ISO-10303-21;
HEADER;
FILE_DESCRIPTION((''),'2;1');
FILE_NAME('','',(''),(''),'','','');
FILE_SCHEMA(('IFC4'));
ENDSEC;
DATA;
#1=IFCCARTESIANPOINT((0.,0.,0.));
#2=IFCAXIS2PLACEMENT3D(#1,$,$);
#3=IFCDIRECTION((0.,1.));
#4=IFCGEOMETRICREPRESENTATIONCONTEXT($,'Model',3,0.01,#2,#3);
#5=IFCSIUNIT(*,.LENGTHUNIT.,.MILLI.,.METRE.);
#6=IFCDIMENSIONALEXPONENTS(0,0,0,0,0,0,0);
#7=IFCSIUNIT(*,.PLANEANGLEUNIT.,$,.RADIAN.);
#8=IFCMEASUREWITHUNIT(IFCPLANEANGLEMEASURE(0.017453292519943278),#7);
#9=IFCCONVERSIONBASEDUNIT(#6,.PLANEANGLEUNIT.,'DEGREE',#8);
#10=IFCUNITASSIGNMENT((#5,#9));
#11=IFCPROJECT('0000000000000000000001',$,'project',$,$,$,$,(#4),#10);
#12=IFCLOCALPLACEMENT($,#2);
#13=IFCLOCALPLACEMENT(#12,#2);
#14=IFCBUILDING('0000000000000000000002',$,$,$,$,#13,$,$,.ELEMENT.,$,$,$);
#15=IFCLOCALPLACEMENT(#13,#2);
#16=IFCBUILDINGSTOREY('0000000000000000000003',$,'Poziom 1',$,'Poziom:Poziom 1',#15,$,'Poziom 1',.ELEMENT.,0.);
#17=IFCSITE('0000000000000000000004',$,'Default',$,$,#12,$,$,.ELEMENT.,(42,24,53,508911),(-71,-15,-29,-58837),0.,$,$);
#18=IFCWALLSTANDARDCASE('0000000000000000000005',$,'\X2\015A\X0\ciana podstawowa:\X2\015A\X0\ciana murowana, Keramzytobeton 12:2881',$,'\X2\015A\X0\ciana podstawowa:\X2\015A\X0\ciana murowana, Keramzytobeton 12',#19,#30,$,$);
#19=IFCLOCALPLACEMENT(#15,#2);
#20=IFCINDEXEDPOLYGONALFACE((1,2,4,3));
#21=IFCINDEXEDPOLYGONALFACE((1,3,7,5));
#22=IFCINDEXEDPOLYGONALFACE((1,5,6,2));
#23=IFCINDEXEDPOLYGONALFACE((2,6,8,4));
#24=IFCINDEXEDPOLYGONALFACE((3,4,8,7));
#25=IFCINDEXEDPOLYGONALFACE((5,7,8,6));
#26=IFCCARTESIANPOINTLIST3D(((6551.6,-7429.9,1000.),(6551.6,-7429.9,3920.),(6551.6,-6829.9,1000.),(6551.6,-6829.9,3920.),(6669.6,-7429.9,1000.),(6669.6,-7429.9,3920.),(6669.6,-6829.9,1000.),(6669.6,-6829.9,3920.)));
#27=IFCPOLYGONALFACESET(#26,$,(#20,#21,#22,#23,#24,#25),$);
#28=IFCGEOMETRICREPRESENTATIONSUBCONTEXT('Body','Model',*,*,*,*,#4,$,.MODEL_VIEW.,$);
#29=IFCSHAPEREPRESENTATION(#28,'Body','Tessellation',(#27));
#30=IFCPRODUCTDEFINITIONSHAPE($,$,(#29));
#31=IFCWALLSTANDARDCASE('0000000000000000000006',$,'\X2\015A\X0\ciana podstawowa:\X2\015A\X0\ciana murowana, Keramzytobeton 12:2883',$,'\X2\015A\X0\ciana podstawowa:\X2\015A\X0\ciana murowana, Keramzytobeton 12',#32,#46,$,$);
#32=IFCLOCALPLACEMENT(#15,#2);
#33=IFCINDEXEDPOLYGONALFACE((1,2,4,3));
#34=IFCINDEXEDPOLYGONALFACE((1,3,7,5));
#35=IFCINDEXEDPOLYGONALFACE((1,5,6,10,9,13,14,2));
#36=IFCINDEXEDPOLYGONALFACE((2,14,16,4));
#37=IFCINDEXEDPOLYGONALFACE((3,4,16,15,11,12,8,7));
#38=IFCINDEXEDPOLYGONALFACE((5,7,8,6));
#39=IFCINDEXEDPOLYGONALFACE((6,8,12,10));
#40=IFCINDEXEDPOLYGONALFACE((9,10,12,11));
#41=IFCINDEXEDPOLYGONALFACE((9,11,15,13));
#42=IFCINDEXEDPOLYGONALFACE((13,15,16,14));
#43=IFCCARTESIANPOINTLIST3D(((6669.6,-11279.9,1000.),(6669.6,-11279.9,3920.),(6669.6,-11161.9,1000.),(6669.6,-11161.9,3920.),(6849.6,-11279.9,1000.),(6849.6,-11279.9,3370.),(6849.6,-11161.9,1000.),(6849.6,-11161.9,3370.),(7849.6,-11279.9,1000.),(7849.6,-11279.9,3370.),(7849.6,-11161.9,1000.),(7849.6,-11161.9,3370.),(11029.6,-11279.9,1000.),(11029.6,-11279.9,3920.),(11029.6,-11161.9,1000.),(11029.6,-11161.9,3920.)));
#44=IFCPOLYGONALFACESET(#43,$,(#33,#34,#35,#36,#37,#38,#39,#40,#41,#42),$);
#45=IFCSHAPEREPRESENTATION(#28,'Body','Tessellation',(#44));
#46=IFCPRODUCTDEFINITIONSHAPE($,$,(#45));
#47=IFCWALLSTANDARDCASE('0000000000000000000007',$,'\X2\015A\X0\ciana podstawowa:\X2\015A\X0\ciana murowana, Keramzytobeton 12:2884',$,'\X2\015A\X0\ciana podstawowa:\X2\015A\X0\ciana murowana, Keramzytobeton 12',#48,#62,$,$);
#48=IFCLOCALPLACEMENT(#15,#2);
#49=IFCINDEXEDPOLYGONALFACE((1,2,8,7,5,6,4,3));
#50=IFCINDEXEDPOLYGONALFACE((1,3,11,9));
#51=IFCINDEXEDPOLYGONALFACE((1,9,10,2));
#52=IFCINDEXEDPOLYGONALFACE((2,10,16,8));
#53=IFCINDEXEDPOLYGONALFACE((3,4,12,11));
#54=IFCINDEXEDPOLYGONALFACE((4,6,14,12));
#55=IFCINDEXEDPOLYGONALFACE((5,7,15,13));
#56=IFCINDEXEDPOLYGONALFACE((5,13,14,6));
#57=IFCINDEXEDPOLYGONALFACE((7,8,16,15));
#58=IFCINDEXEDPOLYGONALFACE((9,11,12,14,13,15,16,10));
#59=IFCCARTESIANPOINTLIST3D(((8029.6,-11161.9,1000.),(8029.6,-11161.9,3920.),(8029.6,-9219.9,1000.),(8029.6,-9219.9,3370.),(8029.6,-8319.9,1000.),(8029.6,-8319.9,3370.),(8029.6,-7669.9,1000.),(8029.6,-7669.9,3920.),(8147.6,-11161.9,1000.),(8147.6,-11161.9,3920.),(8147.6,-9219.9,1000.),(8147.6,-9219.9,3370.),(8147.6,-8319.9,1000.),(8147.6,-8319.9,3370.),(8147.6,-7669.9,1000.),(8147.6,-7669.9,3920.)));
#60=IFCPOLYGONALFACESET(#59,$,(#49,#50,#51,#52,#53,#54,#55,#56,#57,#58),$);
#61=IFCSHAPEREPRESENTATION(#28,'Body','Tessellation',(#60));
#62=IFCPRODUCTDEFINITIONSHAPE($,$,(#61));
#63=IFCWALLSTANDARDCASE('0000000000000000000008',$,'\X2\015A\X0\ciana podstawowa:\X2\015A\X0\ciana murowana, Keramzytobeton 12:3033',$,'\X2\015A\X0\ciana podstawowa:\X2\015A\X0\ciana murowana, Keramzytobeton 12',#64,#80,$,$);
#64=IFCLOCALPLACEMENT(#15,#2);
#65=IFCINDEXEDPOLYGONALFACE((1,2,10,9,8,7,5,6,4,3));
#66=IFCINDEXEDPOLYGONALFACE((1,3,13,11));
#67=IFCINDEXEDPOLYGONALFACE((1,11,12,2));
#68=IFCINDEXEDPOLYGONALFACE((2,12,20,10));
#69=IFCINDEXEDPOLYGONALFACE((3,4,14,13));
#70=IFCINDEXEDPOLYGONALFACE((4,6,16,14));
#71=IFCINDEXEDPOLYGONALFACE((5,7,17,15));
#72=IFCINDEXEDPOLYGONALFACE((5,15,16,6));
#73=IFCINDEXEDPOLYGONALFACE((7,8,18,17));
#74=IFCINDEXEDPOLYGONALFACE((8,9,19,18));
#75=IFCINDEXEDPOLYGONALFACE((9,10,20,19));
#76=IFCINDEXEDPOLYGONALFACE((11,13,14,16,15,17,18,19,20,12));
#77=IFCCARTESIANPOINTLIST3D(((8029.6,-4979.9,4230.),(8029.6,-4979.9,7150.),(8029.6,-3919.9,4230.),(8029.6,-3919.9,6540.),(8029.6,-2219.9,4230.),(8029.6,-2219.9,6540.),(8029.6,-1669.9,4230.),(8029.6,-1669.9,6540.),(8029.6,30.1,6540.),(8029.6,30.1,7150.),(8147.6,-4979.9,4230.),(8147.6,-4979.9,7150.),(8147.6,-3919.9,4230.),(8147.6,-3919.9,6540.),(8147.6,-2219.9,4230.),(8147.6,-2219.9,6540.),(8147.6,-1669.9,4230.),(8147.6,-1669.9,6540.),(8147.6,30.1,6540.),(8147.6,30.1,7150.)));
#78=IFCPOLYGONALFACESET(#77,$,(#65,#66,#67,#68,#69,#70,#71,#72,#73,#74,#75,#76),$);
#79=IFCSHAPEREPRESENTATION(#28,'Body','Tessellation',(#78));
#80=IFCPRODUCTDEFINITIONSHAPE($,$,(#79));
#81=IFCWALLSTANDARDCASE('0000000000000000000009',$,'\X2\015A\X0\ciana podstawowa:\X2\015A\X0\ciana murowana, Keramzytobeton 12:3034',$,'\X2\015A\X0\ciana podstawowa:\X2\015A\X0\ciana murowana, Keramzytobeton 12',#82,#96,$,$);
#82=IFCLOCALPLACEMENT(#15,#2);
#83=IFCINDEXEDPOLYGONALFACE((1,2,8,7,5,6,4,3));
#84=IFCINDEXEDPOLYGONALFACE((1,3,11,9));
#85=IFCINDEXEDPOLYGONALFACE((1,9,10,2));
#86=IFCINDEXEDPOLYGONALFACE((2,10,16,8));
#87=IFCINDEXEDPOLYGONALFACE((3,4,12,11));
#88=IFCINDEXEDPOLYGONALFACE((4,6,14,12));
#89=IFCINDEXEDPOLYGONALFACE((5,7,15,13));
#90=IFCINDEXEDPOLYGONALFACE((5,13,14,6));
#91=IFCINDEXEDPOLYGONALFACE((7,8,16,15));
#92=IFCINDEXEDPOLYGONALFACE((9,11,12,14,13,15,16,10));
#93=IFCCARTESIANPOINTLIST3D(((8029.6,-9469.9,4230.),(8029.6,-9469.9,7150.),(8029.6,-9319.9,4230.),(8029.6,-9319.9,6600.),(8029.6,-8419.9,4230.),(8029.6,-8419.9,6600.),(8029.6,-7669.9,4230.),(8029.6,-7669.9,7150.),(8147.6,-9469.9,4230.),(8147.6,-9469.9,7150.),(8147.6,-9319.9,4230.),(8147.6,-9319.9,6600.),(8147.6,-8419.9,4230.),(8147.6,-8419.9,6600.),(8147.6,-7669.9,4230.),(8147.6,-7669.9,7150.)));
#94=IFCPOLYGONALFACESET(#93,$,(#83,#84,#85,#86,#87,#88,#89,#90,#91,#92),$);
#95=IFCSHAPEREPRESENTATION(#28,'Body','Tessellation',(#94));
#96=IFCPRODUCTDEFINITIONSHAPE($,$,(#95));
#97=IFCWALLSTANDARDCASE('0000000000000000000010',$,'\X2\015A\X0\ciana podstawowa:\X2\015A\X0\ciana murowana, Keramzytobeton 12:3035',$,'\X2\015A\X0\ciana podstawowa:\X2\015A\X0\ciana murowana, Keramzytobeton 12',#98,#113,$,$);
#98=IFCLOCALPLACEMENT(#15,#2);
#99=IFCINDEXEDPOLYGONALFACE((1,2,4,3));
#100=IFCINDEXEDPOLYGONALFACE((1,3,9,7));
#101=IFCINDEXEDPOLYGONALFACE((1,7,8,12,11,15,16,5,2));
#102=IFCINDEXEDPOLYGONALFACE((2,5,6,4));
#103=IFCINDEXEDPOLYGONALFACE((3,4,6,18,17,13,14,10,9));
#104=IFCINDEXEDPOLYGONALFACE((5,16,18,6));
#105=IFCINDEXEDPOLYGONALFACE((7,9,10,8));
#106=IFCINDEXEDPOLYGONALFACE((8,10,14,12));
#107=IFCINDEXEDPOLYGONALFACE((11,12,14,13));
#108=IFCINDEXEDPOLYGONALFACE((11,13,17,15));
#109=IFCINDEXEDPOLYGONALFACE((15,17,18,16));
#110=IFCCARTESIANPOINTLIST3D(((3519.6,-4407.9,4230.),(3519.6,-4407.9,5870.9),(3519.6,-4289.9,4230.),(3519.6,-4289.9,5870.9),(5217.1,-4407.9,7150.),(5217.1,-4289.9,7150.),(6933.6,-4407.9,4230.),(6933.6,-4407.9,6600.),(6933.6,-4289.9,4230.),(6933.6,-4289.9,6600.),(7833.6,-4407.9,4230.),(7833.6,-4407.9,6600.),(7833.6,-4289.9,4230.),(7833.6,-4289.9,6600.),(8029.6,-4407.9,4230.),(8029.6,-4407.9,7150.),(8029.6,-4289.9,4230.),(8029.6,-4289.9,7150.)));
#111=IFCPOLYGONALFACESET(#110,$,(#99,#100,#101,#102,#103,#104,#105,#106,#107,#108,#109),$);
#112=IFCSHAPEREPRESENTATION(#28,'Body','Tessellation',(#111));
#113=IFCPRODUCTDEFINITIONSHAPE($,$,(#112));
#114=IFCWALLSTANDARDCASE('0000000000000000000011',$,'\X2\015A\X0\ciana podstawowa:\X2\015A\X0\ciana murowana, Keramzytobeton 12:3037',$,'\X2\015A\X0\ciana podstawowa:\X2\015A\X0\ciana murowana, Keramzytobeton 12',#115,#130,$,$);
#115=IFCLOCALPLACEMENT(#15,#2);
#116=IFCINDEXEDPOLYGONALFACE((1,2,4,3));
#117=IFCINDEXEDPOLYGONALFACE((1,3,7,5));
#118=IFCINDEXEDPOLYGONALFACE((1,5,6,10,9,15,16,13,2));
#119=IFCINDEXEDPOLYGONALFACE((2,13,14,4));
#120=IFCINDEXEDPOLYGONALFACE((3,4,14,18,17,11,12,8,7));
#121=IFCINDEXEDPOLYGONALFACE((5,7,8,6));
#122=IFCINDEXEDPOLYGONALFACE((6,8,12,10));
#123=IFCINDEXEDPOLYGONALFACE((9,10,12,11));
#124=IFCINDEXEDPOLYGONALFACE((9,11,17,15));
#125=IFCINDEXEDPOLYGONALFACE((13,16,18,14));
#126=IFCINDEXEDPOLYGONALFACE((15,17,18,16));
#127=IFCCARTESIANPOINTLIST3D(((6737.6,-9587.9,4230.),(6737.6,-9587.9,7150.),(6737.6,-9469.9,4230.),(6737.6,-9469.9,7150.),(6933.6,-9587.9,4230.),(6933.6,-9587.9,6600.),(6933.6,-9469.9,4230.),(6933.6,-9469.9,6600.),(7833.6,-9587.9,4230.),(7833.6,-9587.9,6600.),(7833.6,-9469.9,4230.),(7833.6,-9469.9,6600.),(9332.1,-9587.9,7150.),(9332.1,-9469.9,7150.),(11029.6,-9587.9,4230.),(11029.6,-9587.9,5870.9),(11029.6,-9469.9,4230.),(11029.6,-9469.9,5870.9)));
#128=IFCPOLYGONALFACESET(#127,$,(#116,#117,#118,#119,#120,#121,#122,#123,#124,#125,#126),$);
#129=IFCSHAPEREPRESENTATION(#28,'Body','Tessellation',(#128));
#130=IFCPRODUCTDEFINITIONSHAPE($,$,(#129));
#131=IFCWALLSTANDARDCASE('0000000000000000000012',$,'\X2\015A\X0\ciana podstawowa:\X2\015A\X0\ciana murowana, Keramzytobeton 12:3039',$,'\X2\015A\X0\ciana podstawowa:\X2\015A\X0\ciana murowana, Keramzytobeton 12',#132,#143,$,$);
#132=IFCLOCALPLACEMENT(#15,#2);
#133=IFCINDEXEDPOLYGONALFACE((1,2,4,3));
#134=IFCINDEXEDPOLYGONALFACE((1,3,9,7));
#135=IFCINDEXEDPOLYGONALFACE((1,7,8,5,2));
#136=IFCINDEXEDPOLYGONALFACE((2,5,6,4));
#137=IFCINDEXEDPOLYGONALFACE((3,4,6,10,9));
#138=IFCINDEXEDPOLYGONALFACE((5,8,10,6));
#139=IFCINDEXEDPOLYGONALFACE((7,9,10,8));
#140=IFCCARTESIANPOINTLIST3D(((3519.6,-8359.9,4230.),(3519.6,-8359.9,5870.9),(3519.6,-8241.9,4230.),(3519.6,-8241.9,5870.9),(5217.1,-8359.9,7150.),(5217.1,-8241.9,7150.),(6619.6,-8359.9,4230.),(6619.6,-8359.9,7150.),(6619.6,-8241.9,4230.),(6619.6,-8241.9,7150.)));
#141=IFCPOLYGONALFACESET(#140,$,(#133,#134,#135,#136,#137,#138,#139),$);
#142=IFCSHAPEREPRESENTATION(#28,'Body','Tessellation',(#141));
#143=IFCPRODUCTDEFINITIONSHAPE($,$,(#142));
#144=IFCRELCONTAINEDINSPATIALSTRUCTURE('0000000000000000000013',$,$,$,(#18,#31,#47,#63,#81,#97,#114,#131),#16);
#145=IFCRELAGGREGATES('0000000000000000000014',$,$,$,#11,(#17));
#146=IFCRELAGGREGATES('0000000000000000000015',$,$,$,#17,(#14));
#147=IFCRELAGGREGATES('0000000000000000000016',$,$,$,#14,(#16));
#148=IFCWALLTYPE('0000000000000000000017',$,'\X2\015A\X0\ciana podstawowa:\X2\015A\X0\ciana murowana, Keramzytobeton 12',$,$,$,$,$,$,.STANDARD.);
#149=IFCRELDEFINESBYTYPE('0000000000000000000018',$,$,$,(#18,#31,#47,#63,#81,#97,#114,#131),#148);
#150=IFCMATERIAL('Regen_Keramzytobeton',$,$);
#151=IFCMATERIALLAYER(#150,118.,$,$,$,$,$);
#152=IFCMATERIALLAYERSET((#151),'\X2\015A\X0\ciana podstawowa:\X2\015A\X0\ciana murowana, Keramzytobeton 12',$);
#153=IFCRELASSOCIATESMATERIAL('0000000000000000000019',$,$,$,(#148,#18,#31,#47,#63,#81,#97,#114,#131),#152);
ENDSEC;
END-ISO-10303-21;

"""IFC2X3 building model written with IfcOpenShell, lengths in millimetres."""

from ifc_helpers import new_model, entity, si_unit, converted_unit, direction, frame, frame_2d, origin, place, context, subcontext, project, spatial, rectangle, extrude, clip, halfspace, material, layer, layer_set, layer_usage, type_object, element, save


model = new_model("IFC2X3")

# Units and contexts
model_context = context("Model", 3, precision=0.01, world=origin(), true_north=direction((0.0, 1.0)))
body_context = subcontext(model_context, "Body", "Model", "MODEL_VIEW")
ifc_project = project(units=[si_unit("LENGTHUNIT", "METRE", prefix="MILLI"), converted_unit("PLANEANGLEUNIT", "DEGREE", entity("IfcPlaneAngleMeasure", 0.017453292519943278), si_unit("PLANEANGLEUNIT", "RADIAN"), dimensions=[0, 0, 0, 0, 0, 0, 0])], contexts=[model_context])

# Site, building, storey
site_placement = place(None, origin())
site = spatial("IfcSite", under=ifc_project, at=site_placement, Name="Default", CompositionType="ELEMENT", RefLatitude=(42, 24, 53, 508911), RefLongitude=(-71, -15, -29, -58837), RefElevation=0.0)
building_placement = place(site_placement, origin())
building = spatial("IfcBuilding", under=site, at=building_placement, CompositionType="ELEMENT")
storey_placement = place(building_placement, origin())
storey = spatial("IfcBuildingStorey", under=building, at=storey_placement, Name="Poziom 1", ObjectType="Poziom:Poziom 1", LongName="Poziom 1", CompositionType="ELEMENT", Elevation=0.0)

# Wall
ifc_material_1 = material(Name="Regen_Keramzytobeton")
ifc_layer_1 = layer(ifc_material_1, 118.0)
ifc_layer_set_1 = layer_set([ifc_layer_1], Name="Ściana podstawowa:Ściana murowana, Keramzytobeton 12")
ifc_layer_usage_1 = layer_usage(ifc_layer_set_1, "AXIS2", "NEGATIVE", 59.0)
wall_type_1 = type_object("IfcWallType", Name="Ściana podstawowa:Ściana murowana, Keramzytobeton 12", PredefinedType="STANDARD", material=ifc_layer_set_1)
wall_1_placement = place(storey_placement, frame((6610.6, -7429.9, 1000.0), z_axis=(0.0, 0.0, 1.0), x_axis=(0.0, 1.0, 0.0)))
element("IfcWallStandardCase", 1, at=wall_1_placement, inside=storey, type_object=wall_type_1, material=ifc_layer_usage_1, Name="Ściana podstawowa:Ściana murowana, Keramzytobeton 12:2881", ObjectType="Ściana podstawowa:Ściana murowana, Keramzytobeton 12", context=body_context, shape_type="SweptSolid", body=[
    extrude(rectangle(XDim=600.0, YDim=118.0, at=frame_2d((300.0, 0.0), x_axis=(-1.0, 0.0))), origin(), (0.0, 0.0, 1.0), 2920.0),
])

# Walls, openings
ifc_layer_usage_2 = layer_usage(ifc_layer_set_1, "AXIS2", "NEGATIVE", 59.0)
wall_2_placement = place(storey_placement, frame((11029.6, -11220.9, 1000.0), z_axis=(0.0, 0.0, 1.0), x_axis=(-1.0, 0.0, 0.0)))
wall_2 = element("IfcWallStandardCase", 2, at=wall_2_placement, inside=storey, type_object=wall_type_1, material=ifc_layer_usage_2, Name="Ściana podstawowa:Ściana murowana, Keramzytobeton 12:2883", ObjectType="Ściana podstawowa:Ściana murowana, Keramzytobeton 12", context=body_context, shape_type="SweptSolid", body=[
    extrude(rectangle(XDim=4360.0, YDim=118.0, at=frame_2d((2180.0, 0.0), x_axis=(1.0, 0.0))), origin(), (0.0, 0.0, 1.0), 2920.0),
])
opening_1_placement = place(wall_2_placement, frame((11029.6, -11220.9, -1000.0), z_axis=(0.0, 0.0, 1.0), x_axis=(-1.0, 0.0, 0.0)))
element("IfcOpeningElement", 3, at=opening_1_placement, cuts=wall_2, ObjectType="Opening", context=body_context, shape_type="SweptSolid", body=[
    extrude(rectangle(XDim=2370.0, YDim=1000.0, at=frame_2d((0.0, 0.0), x_axis=(0.0, 1.0))), frame((7349.6, -9637.9, 2185.0), z_axis=(0.0, -1.0, 0.0), x_axis=(-1.0, 0.0, 0.0)), (0.0, 0.0, 1.0), 3048.0),
])
ifc_layer_usage_3 = layer_usage(ifc_layer_set_1, "AXIS2", "NEGATIVE", 59.0)
wall_3_placement = place(storey_placement, frame((8088.6, -7669.9, 1000.0), z_axis=(0.0, 0.0, 1.0), x_axis=(0.0, -1.0, 0.0)))
wall_3 = element("IfcWallStandardCase", 4, at=wall_3_placement, inside=storey, type_object=wall_type_1, material=ifc_layer_usage_3, Name="Ściana podstawowa:Ściana murowana, Keramzytobeton 12:2884", ObjectType="Ściana podstawowa:Ściana murowana, Keramzytobeton 12", context=body_context, shape_type="SweptSolid", body=[
    extrude(rectangle(XDim=3492.0, YDim=118.0, at=frame_2d((1746.0, 0.0), x_axis=(1.0, 0.0))), origin(), (0.0, 0.0, 1.0), 2920.0),
])
opening_2_placement = place(wall_3_placement, frame((-7669.9, -8088.6, -1000.0), z_axis=(0.0, 0.0, 1.0), x_axis=(0.0, 1.0, 0.0)))
element("IfcOpeningElement", 5, at=opening_2_placement, cuts=wall_3, ObjectType="Opening", context=body_context, shape_type="SweptSolid", body=[
    extrude(rectangle(XDim=2370.0, YDim=900.0, at=frame_2d((0.0, 0.0), x_axis=(0.0, 1.0))), frame((6505.6, -8769.9, 2185.0), z_axis=(1.0, 0.0, 0.0), x_axis=(0.0, -1.0, 0.0)), (0.0, 0.0, 1.0), 3048.0),
])

# Wall, openings
ifc_layer_usage_4 = layer_usage(ifc_layer_set_1, "AXIS2", "NEGATIVE", 59.0)
wall_4_placement = place(storey_placement, frame((8088.6, -4979.9, 4230.0), z_axis=(0.0, 0.0, 1.0), x_axis=(0.0, 1.0, 0.0)))
wall_4 = element("IfcWallStandardCase", 6, at=wall_4_placement, inside=storey, type_object=wall_type_1, material=ifc_layer_usage_4, Name="Ściana podstawowa:Ściana murowana, Keramzytobeton 12:3033", ObjectType="Ściana podstawowa:Ściana murowana, Keramzytobeton 12", context=body_context, shape_type="SweptSolid", body=[
    extrude(rectangle(XDim=5010.0, YDim=118.0, at=frame_2d((2505.0, 0.0), x_axis=(1.0, 0.0))), origin(), (0.0, 0.0, 1.0), 2920.0),
])
opening_3_placement = place(wall_4_placement, frame((4979.9, 8088.6, -4230.0), z_axis=(0.0, 0.0, 1.0), x_axis=(0.0, -1.0, 0.0)))
element("IfcOpeningElement", 7, at=opening_3_placement, cuts=wall_4, ObjectType="Opening", context=body_context, shape_type="SweptSolid", body=[
    extrude(rectangle(XDim=2310.0, YDim=1700.0, at=frame_2d((0.0, 0.0), x_axis=(0.0, 1.0))), frame((9671.6, -819.9, 5385.0), z_axis=(-1.0, 0.0, 0.0), x_axis=(0.0, 1.0, 0.0)), (0.0, 0.0, 1.0), 3048.0),
])
opening_4_placement = place(wall_4_placement, frame((4979.9, 8088.6, -4230.0), z_axis=(0.0, 0.0, 1.0), x_axis=(0.0, -1.0, 0.0)))
element("IfcOpeningElement", 8, at=opening_4_placement, cuts=wall_4, ObjectType="Opening", context=body_context, shape_type="SweptSolid", body=[
    extrude(rectangle(XDim=2310.0, YDim=1700.0, at=frame_2d((0.0, 0.0), x_axis=(0.0, 1.0))), frame((9671.6, -3069.9, 5385.0), z_axis=(-1.0, 0.0, 0.0), x_axis=(0.0, 1.0, 0.0)), (0.0, 0.0, 1.0), 3048.0),
])

# Walls, openings
ifc_layer_usage_5 = layer_usage(ifc_layer_set_1, "AXIS2", "NEGATIVE", 59.0)
wall_5_placement = place(storey_placement, frame((8088.6, -7669.9, 4230.0), z_axis=(0.0, 0.0, 1.0), x_axis=(0.0, -1.0, 0.0)))
wall_5 = element("IfcWallStandardCase", 9, at=wall_5_placement, inside=storey, type_object=wall_type_1, material=ifc_layer_usage_5, Name="Ściana podstawowa:Ściana murowana, Keramzytobeton 12:3034", ObjectType="Ściana podstawowa:Ściana murowana, Keramzytobeton 12", context=body_context, shape_type="SweptSolid", body=[
    extrude(rectangle(XDim=1800.0, YDim=118.0, at=frame_2d((900.0, 0.0), x_axis=(1.0, 0.0))), origin(), (0.0, 0.0, 1.0), 2920.0),
])
opening_5_placement = place(wall_5_placement, frame((-7669.9, -8088.6, -4230.0), z_axis=(0.0, 0.0, 1.0), x_axis=(0.0, 1.0, 0.0)))
element("IfcOpeningElement", 10, at=opening_5_placement, cuts=wall_5, ObjectType="Opening", context=body_context, shape_type="SweptSolid", body=[
    extrude(rectangle(XDim=2370.0, YDim=900.0, at=frame_2d((0.0, 0.0), x_axis=(0.0, 1.0))), frame((6505.6, -8869.9, 5415.0), z_axis=(1.0, 0.0, 0.0), x_axis=(0.0, -1.0, 0.0)), (0.0, 0.0, 1.0), 3048.0),
])
ifc_layer_usage_6 = layer_usage(ifc_layer_set_1, "AXIS2", "NEGATIVE", 59.0)
wall_6_placement = place(storey_placement, frame((8029.6, -4348.9, 4230.0), z_axis=(0.0, 0.0, 1.0), x_axis=(-1.0, 0.0, 0.0)))
wall_6 = element("IfcWallStandardCase", 11, at=wall_6_placement, inside=storey, type_object=wall_type_1, material=ifc_layer_usage_6, Name="Ściana podstawowa:Ściana murowana, Keramzytobeton 12:3035", ObjectType="Ściana podstawowa:Ściana murowana, Keramzytobeton 12", context=body_context, shape_type="Clipping", body=[
    clip(extrude(rectangle(XDim=4510.0, YDim=118.0, at=frame_2d((2255.0, 0.0), x_axis=(-1.0, 0.0))), origin(), (0.0, 0.0, 1.0), 2920.0), halfspace(frame((2812.5, -59.0, 2920.0), z_axis=(0.601815, 0.0, 0.798636), x_axis=(0.0, 1.0, 0.0)), False)),
])
opening_6_placement = place(wall_6_placement, frame((8029.6, -4348.9, -4230.0), z_axis=(0.0, 0.0, 1.0), x_axis=(-1.0, 0.0, 0.0)))
element("IfcOpeningElement", 12, at=opening_6_placement, cuts=wall_6, ObjectType="Opening", context=body_context, shape_type="SweptSolid", body=[
    extrude(rectangle(XDim=2370.0, YDim=900.0, at=frame_2d((0.0, 0.0), x_axis=(0.0, 1.0))), frame((7383.6, -2765.9, 5415.0), z_axis=(0.0, -1.0, 0.0), x_axis=(-1.0, 0.0, 0.0)), (0.0, 0.0, 1.0), 3048.0),
])
ifc_layer_usage_7 = layer_usage(ifc_layer_set_1, "AXIS2", "NEGATIVE", 59.0)
wall_7_placement = place(storey_placement, frame((11029.6, -9528.9, 4230.0), z_axis=(0.0, 0.0, 1.0), x_axis=(-1.0, 0.0, 0.0)))
wall_7 = element("IfcWallStandardCase", 13, at=wall_7_placement, inside=storey, type_object=wall_type_1, material=ifc_layer_usage_7, Name="Ściana podstawowa:Ściana murowana, Keramzytobeton 12:3037", ObjectType="Ściana podstawowa:Ściana murowana, Keramzytobeton 12", context=body_context, shape_type="Clipping", body=[
    clip(extrude(rectangle(XDim=4292.0, YDim=118.0, at=frame_2d((2146.0, 0.0), x_axis=(-1.0, 0.0))), origin(), (0.0, 0.0, 1.0), 2920.0), halfspace(frame((0.0, -59.0, 1640.9), z_axis=(-0.601815, 0.0, 0.798636), x_axis=(0.0, 1.0, 0.0)), False)),
])
opening_7_placement = place(wall_7_placement, frame((11029.6, -9528.9, -4230.0), z_axis=(0.0, 0.0, 1.0), x_axis=(-1.0, 0.0, 0.0)))
element("IfcOpeningElement", 14, at=opening_7_placement, cuts=wall_7, ObjectType="Opening", context=body_context, shape_type="SweptSolid", body=[
    extrude(rectangle(XDim=2370.0, YDim=900.0, at=frame_2d((0.0, 0.0), x_axis=(0.0, 1.0))), frame((7383.6, -7945.9, 5415.0), z_axis=(0.0, -1.0, 0.0), x_axis=(-1.0, 0.0, 0.0)), (0.0, 0.0, 1.0), 3048.0),
])

# Wall
ifc_layer_usage_8 = layer_usage(ifc_layer_set_1, "AXIS2", "NEGATIVE", 59.0)
wall_8_placement = place(storey_placement, frame((6619.6, -8300.9, 4230.0), z_axis=(0.0, 0.0, 1.0), x_axis=(-1.0, 0.0, 0.0)))
element("IfcWallStandardCase", 15, at=wall_8_placement, inside=storey, type_object=wall_type_1, material=ifc_layer_usage_8, Name="Ściana podstawowa:Ściana murowana, Keramzytobeton 12:3039", ObjectType="Ściana podstawowa:Ściana murowana, Keramzytobeton 12", context=body_context, shape_type="Clipping", body=[
    clip(extrude(rectangle(XDim=3100.0, YDim=118.0, at=frame_2d((1550.0, 0.0), x_axis=(-1.0, 0.0))), origin(), (0.0, 0.0, 1.0), 2920.0), halfspace(frame((1402.5, -59.0, 2920.0), z_axis=(0.601815, 0.0, 0.798636), x_axis=(0.0, 1.0, 0.0)), False)),
])

save(model, "model.ifc")
